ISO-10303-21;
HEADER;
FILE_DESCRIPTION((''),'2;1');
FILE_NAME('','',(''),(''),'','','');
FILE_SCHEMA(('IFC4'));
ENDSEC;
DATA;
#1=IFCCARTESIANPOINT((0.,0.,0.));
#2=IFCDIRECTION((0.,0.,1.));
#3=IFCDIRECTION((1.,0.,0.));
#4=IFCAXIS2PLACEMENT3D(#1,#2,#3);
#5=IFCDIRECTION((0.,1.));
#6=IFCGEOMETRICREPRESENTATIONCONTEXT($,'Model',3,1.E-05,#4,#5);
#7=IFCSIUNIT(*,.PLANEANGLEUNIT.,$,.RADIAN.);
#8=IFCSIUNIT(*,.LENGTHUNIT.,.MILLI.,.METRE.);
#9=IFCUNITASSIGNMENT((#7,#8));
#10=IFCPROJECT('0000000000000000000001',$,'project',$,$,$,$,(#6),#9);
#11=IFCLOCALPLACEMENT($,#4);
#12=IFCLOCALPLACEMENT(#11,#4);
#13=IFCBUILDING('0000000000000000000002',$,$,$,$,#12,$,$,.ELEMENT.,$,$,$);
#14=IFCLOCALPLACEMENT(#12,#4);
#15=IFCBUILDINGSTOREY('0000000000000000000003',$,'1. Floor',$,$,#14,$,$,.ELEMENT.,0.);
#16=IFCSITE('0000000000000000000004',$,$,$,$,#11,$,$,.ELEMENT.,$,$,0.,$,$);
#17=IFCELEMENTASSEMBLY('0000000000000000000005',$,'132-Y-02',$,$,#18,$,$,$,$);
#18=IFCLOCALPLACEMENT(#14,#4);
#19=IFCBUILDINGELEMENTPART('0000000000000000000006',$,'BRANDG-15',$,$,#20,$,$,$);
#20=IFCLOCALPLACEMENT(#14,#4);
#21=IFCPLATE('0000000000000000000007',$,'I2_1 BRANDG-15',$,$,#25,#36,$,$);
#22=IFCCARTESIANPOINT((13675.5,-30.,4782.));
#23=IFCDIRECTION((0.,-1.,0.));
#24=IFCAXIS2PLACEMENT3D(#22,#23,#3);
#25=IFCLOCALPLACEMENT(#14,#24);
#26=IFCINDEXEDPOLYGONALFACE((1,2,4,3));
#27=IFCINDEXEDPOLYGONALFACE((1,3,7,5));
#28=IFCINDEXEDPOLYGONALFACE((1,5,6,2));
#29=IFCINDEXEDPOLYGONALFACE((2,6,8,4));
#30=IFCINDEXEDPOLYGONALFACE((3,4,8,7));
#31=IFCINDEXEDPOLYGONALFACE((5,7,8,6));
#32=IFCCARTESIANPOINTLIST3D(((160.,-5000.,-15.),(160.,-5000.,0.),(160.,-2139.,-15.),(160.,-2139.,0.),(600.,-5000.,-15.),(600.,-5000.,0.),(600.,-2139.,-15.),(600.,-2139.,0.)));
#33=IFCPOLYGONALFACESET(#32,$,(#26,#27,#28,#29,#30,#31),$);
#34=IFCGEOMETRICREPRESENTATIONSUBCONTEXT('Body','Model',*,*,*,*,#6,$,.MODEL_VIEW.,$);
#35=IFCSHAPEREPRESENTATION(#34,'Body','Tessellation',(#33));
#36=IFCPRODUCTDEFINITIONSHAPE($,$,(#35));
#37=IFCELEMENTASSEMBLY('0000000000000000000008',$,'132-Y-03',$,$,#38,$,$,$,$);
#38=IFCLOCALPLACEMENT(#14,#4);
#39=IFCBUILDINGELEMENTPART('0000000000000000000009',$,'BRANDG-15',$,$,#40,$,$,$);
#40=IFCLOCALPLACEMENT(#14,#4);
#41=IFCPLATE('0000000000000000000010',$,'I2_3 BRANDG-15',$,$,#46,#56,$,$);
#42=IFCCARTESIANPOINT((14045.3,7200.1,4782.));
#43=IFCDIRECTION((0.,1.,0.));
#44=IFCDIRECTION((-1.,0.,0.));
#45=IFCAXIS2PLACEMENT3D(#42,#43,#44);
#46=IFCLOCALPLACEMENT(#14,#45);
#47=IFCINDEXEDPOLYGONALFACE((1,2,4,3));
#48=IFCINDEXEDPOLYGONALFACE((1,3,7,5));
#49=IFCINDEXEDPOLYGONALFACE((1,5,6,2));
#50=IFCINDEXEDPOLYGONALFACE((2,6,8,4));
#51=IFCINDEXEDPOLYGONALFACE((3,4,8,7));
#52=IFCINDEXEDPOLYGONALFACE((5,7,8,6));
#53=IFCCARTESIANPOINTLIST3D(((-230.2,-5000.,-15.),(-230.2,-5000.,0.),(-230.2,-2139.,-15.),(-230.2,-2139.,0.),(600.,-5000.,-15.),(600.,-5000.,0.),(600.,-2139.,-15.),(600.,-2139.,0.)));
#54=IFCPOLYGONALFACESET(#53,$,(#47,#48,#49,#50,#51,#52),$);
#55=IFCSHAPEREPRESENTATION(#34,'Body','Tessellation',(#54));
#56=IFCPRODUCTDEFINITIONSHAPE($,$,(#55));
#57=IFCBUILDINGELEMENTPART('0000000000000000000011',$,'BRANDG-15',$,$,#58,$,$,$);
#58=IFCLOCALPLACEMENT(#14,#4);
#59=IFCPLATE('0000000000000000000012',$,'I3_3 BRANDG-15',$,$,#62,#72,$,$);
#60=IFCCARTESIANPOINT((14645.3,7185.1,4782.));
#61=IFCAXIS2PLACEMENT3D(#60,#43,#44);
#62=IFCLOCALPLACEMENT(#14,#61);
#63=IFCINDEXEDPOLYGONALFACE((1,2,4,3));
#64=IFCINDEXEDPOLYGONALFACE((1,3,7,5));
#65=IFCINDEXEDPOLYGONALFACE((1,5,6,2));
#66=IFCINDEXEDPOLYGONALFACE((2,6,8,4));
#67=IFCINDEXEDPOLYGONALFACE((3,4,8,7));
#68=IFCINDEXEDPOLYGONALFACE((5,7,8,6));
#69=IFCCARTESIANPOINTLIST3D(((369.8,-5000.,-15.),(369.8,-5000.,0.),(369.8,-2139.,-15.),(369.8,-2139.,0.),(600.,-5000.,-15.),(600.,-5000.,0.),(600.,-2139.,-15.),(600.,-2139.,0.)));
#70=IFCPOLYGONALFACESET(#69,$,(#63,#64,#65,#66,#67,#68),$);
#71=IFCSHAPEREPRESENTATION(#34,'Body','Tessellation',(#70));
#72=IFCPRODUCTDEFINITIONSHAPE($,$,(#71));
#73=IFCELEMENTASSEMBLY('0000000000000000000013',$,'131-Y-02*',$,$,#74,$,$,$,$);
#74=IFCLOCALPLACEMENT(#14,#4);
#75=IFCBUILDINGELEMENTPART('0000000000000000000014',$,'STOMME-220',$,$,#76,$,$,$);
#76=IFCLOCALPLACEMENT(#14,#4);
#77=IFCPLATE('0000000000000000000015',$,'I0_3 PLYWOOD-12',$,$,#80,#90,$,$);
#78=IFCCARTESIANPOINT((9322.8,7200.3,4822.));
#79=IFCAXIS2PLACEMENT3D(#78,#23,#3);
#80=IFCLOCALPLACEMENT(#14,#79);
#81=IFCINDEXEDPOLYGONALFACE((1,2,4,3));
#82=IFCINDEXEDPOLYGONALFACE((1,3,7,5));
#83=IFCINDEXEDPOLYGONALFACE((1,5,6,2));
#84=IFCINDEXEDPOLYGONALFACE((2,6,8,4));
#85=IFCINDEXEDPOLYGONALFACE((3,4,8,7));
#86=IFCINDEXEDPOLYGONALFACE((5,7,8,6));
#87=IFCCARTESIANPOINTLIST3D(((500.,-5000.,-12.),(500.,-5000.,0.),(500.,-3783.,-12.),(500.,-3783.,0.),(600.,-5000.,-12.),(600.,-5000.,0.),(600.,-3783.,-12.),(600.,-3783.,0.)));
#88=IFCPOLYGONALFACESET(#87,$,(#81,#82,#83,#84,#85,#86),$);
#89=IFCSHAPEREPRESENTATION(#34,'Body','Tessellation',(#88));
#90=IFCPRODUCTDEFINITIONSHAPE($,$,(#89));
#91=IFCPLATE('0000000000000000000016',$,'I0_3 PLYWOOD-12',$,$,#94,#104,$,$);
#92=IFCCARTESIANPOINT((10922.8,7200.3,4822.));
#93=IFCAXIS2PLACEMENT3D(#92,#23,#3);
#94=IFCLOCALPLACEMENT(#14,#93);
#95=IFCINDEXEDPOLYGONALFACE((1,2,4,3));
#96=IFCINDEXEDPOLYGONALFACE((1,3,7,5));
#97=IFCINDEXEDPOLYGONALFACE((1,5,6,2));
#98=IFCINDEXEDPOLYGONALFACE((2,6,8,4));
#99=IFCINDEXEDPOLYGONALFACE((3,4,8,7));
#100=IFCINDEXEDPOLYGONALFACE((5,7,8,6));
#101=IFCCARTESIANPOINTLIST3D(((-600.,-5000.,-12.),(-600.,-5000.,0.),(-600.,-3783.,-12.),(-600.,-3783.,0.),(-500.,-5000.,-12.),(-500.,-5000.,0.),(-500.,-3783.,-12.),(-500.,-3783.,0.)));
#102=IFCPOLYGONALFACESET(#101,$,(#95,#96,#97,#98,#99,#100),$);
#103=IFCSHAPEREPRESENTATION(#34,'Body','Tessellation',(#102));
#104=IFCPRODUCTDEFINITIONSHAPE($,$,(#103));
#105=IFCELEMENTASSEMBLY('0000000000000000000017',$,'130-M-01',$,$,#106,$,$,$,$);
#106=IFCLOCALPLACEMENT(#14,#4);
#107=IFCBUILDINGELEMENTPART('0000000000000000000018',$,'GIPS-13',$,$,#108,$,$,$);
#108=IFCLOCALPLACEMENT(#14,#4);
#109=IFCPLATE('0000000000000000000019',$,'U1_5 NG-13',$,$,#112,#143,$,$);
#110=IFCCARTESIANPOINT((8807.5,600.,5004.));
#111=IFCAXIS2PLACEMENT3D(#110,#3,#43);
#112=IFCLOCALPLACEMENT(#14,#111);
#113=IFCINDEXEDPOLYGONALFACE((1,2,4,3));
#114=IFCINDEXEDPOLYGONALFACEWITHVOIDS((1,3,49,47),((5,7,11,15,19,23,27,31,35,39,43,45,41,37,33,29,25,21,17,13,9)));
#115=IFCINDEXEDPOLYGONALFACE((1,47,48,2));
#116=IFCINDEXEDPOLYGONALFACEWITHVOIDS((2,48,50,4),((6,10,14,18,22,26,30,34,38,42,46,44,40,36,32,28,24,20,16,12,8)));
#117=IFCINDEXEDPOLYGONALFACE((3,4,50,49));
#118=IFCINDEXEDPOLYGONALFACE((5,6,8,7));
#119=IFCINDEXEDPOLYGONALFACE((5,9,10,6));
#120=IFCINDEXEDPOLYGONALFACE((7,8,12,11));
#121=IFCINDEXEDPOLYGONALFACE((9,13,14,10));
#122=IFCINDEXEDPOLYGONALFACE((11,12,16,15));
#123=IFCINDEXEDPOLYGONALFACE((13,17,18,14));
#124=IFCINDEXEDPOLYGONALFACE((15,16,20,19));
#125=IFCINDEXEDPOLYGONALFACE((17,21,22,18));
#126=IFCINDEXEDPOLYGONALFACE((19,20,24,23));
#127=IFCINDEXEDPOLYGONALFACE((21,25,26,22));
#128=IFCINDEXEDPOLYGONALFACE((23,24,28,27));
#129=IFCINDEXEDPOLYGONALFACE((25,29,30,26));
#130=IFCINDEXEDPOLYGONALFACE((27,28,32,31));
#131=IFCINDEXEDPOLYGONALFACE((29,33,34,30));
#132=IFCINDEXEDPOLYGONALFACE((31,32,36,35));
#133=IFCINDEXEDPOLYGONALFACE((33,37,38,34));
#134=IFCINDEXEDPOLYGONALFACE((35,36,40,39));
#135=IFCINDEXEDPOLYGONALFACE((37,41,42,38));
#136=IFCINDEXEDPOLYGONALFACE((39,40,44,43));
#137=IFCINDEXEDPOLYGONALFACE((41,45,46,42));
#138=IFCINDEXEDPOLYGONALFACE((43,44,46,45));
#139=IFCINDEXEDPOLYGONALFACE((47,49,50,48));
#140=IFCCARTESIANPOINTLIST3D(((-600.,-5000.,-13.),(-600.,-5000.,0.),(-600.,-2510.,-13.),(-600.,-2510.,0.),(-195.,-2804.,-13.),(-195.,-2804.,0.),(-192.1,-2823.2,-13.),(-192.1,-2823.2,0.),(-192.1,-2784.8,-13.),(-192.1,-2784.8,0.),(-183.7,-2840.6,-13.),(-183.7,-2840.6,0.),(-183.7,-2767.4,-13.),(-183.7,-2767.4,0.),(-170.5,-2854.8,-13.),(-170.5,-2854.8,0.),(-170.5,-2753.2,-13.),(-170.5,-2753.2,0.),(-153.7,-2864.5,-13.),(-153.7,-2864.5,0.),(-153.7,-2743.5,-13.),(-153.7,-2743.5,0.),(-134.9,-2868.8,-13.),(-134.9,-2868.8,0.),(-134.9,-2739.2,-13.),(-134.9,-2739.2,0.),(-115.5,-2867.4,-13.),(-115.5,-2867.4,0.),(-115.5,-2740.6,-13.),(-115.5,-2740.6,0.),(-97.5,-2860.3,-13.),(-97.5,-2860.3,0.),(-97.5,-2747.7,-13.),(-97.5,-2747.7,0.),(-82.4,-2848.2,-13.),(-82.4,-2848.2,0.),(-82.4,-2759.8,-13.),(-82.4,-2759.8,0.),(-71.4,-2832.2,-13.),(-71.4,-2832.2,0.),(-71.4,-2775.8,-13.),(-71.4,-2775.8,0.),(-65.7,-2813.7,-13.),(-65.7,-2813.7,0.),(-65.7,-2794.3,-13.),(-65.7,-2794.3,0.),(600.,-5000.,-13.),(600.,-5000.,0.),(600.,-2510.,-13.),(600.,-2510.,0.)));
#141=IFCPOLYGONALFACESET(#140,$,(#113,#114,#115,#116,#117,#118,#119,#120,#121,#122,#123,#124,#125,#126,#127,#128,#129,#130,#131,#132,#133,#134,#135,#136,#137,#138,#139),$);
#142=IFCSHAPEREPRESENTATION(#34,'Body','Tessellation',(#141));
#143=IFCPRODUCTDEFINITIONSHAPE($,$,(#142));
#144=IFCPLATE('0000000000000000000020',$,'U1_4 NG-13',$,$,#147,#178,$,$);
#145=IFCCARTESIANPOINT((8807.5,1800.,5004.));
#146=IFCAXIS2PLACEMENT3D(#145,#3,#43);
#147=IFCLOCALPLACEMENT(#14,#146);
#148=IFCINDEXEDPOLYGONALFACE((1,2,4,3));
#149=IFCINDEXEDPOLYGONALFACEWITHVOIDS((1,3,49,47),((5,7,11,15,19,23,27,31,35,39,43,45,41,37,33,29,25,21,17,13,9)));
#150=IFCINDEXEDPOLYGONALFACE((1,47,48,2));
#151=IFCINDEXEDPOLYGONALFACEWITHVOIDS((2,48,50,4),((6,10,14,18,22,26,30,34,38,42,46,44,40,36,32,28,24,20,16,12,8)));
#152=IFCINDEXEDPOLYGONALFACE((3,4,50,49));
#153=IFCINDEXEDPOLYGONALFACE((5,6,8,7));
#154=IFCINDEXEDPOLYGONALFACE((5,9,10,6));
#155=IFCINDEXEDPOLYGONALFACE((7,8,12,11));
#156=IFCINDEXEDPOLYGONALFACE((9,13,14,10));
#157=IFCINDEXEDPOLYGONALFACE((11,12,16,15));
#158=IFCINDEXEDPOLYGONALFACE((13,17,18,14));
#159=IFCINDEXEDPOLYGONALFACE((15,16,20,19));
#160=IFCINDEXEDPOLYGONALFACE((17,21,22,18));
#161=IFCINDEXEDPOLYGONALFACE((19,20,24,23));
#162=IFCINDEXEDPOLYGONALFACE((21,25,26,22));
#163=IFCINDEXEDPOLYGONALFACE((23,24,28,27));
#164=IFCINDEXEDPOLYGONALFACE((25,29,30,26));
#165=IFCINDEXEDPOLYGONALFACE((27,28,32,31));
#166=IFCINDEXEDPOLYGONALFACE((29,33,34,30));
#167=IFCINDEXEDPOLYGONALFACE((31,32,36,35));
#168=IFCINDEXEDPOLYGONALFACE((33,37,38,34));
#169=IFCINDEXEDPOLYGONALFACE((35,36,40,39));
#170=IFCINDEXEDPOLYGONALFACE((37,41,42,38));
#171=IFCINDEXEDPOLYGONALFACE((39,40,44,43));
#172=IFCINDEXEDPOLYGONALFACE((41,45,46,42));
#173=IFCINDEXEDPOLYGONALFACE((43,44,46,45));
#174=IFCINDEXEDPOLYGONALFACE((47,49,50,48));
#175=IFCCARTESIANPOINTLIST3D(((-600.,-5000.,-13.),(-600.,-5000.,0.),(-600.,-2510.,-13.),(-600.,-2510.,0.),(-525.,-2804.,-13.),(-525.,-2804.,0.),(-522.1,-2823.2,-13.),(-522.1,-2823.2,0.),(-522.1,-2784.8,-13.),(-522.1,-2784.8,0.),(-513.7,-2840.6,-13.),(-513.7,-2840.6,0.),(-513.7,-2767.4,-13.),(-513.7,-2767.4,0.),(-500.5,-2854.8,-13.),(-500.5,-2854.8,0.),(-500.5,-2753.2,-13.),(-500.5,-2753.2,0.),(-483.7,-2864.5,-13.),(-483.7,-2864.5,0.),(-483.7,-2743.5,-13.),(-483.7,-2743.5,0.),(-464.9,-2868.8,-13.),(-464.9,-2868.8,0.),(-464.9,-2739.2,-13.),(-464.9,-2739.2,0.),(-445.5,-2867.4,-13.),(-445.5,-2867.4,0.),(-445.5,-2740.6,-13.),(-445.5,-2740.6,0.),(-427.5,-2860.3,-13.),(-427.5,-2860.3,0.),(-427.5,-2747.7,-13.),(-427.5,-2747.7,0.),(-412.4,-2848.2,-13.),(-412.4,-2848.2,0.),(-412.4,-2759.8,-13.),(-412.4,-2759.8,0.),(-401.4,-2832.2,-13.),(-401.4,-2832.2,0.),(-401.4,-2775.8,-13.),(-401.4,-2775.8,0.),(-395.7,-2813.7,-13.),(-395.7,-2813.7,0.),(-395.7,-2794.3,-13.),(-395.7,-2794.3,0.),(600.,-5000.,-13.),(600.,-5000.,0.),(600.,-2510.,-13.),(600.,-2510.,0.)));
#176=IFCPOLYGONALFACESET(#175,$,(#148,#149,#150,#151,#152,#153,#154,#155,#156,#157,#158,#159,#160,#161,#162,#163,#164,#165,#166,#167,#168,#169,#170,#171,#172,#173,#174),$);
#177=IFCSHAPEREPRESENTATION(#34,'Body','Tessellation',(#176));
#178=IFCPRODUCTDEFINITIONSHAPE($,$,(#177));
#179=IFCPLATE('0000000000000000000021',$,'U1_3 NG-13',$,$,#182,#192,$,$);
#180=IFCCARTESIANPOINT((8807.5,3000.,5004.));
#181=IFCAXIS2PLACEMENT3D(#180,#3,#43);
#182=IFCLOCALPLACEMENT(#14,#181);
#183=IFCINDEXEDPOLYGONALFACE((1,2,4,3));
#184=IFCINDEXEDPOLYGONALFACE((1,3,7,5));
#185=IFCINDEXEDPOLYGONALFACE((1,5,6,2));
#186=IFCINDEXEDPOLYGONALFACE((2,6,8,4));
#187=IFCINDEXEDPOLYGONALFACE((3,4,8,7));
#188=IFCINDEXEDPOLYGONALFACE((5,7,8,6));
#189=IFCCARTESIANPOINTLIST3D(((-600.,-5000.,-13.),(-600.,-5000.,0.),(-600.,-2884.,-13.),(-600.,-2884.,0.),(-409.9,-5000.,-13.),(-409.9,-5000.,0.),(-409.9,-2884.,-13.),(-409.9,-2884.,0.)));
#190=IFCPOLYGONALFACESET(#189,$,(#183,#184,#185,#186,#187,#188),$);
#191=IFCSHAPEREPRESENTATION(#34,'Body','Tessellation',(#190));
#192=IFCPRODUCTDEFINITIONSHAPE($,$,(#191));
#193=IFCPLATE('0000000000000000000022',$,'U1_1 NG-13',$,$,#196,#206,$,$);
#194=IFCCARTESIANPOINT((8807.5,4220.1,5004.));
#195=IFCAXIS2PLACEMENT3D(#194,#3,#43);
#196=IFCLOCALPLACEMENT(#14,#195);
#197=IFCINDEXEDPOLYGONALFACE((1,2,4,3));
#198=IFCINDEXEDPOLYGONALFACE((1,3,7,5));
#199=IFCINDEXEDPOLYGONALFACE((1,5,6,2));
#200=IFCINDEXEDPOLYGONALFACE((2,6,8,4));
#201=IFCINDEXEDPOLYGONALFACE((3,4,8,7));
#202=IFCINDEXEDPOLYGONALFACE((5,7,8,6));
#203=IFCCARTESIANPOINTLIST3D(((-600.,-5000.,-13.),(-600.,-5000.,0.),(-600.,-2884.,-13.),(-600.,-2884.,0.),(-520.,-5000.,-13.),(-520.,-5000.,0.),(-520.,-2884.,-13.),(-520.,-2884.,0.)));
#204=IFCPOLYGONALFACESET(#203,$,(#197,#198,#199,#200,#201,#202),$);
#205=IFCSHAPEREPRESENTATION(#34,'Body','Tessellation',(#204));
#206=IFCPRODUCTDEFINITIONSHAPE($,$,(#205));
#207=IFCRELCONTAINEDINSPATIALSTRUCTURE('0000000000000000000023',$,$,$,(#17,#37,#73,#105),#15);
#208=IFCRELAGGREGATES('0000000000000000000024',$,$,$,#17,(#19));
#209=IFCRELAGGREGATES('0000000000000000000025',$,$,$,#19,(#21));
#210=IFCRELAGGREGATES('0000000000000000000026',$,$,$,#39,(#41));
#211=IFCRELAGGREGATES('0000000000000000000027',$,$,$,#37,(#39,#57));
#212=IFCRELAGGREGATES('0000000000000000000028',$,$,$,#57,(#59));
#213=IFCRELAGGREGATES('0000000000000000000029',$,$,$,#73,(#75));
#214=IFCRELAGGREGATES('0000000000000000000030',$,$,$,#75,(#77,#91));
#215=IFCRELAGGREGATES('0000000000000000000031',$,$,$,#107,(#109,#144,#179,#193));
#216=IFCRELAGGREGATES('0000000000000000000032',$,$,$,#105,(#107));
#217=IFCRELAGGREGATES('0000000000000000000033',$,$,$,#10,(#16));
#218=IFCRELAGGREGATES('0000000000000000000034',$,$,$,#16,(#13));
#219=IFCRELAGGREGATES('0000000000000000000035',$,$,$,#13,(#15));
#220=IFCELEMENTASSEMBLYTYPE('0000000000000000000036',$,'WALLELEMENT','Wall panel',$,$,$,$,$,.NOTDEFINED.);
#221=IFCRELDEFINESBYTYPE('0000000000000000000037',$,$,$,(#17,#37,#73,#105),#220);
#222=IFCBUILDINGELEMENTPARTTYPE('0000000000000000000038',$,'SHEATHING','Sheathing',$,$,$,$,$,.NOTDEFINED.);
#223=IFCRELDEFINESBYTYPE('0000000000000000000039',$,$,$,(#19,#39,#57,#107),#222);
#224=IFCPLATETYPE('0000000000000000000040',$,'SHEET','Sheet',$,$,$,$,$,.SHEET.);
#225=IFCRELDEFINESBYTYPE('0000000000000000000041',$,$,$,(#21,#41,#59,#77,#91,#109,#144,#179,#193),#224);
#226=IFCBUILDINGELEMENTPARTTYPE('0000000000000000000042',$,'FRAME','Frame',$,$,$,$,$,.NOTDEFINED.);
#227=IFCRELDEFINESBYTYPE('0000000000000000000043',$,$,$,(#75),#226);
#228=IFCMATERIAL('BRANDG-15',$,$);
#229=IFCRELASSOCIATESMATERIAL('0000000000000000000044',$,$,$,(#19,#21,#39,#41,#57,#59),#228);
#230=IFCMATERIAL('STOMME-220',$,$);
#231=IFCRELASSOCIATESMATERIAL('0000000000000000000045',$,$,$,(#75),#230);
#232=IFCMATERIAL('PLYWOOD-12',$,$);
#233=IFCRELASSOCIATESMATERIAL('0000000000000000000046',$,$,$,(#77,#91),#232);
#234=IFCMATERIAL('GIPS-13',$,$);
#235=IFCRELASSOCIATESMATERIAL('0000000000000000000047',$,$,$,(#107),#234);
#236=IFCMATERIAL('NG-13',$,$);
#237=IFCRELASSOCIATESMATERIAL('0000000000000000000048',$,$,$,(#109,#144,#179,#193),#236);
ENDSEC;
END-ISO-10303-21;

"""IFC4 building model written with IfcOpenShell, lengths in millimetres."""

from ifc_helpers import new_model, si_unit, direction, frame, origin_with_axes, origin_2d_with_axis, place, context, subcontext, project, spatial, rectangle, circle, extrude, boolean, material, type_object, element, aggregate, save


model = new_model("IFC4")

# Units and contexts
model_context = context("Model", 3, precision=1e-05, world=origin_with_axes(), true_north=direction((0.0, 1.0)))
body_context = subcontext(model_context, "Body", "Model", "MODEL_VIEW")
ifc_project = project(units=[si_unit("PLANEANGLEUNIT", "RADIAN"), si_unit("LENGTHUNIT", "METRE", prefix="MILLI")], contexts=[model_context])

# Site, building, storey
site_placement = place(None, origin_with_axes())
site = spatial("IfcSite", under=ifc_project, at=site_placement, CompositionType="ELEMENT", RefElevation=0.0)
building_placement = place(site_placement, origin_with_axes())
building = spatial("IfcBuilding", under=site, at=building_placement, CompositionType="ELEMENT")
storey_placement = place(building_placement, origin_with_axes())
storey = spatial("IfcBuildingStorey", under=building, at=storey_placement, Name="1. Floor", CompositionType="ELEMENT", Elevation=0.0)

# Element assembly, building element part, plate
element_assembly_type = type_object("IfcElementAssemblyType", Name="WALLELEMENT", Description="Wall panel", PredefinedType="NOTDEFINED")
assembly_1_placement = place(storey_placement, origin_with_axes())
assembly_1 = element("IfcElementAssembly", 1, at=assembly_1_placement, inside=storey, type_object=element_assembly_type, Name="132-Y-02")
ifc_material_1 = material(Name="BRANDG-15")
building_element_part_type_1 = type_object("IfcBuildingElementPartType", Name="SHEATHING", Description="Sheathing", PredefinedType="NOTDEFINED")
building_element_part_1_placement = place(storey_placement, origin_with_axes())
building_element_part_1 = element("IfcBuildingElementPart", 2, at=building_element_part_1_placement, type_object=building_element_part_type_1, material=ifc_material_1, Name="BRANDG-15")
aggregate(assembly_1, [building_element_part_1])
plate_type = type_object("IfcPlateType", Name="SHEET", Description="Sheet", PredefinedType="SHEET")
plate_1_placement = place(storey_placement, frame((13675.5, -30.0, 4782.0), z_axis=(0.0, -1.0, 0.0), x_axis=(1.0, 0.0, 0.0)))
plate_1 = element("IfcPlate", 3, at=plate_1_placement, type_object=plate_type, material=ifc_material_1, Name="I2_1 BRANDG-15", context=body_context, shape_type="SweptSolid", body=[
    extrude(rectangle(XDim=15.0, YDim=440.0, at=origin_2d_with_axis()), frame((380.0, -5000.0, -7.5), z_axis=(0.0, 1.0, 0.0), x_axis=(0.0, 0.0, 1.0)), (0.0, 0.0, 1.0), 2861.0),
])
aggregate(building_element_part_1, [plate_1])

# Element assembly, building element parts, plates
assembly_2_placement = place(storey_placement, origin_with_axes())
assembly_2 = element("IfcElementAssembly", 4, at=assembly_2_placement, inside=storey, type_object=element_assembly_type, Name="132-Y-03")
building_element_part_2_placement = place(storey_placement, origin_with_axes())
building_element_part_2 = element("IfcBuildingElementPart", 5, at=building_element_part_2_placement, type_object=building_element_part_type_1, material=ifc_material_1, Name="BRANDG-15")
plate_2_placement = place(storey_placement, frame((14045.3, 7200.1, 4782.0), z_axis=(0.0, 1.0, 0.0), x_axis=(-1.0, 0.0, 0.0)))
plate_2 = element("IfcPlate", 6, at=plate_2_placement, type_object=plate_type, material=ifc_material_1, Name="I2_3 BRANDG-15", context=body_context, shape_type="SweptSolid", body=[
    extrude(rectangle(XDim=15.0, YDim=830.2, at=origin_2d_with_axis()), frame((184.9, -5000.0, -7.5), z_axis=(0.0, 1.0, 0.0), x_axis=(0.0, 0.0, 1.0)), (0.0, 0.0, 1.0), 2861.0),
])
aggregate(building_element_part_2, [plate_2])
building_element_part_3_placement = place(storey_placement, origin_with_axes())
building_element_part_3 = element("IfcBuildingElementPart", 7, at=building_element_part_3_placement, type_object=building_element_part_type_1, material=ifc_material_1, Name="BRANDG-15")
aggregate(assembly_2, [building_element_part_2, building_element_part_3])
plate_3_placement = place(storey_placement, frame((14645.3, 7185.1, 4782.0), z_axis=(0.0, 1.0, 0.0), x_axis=(-1.0, 0.0, 0.0)))
plate_3 = element("IfcPlate", 8, at=plate_3_placement, type_object=plate_type, material=ifc_material_1, Name="I3_3 BRANDG-15", context=body_context, shape_type="SweptSolid", body=[
    extrude(rectangle(XDim=15.0, YDim=230.2, at=origin_2d_with_axis()), frame((484.9, -5000.0, -7.5), z_axis=(0.0, 1.0, 0.0), x_axis=(0.0, 0.0, 1.0)), (0.0, 0.0, 1.0), 2861.0),
])
aggregate(building_element_part_3, [plate_3])

# Element assembly, building element part, plates
assembly_3_placement = place(storey_placement, origin_with_axes())
assembly_3 = element("IfcElementAssembly", 9, at=assembly_3_placement, inside=storey, type_object=element_assembly_type, Name="131-Y-02*")
ifc_material_2 = material(Name="STOMME-220")
building_element_part_type_2 = type_object("IfcBuildingElementPartType", Name="FRAME", Description="Frame", PredefinedType="NOTDEFINED")
building_element_part_4_placement = place(storey_placement, origin_with_axes())
building_element_part_4 = element("IfcBuildingElementPart", 10, at=building_element_part_4_placement, type_object=building_element_part_type_2, material=ifc_material_2, Name="STOMME-220")
aggregate(assembly_3, [building_element_part_4])
ifc_material_3 = material(Name="PLYWOOD-12")
plate_4_placement = place(storey_placement, frame((9322.8, 7200.3, 4822.0), z_axis=(0.0, -1.0, 0.0), x_axis=(1.0, 0.0, 0.0)))
plate_4 = element("IfcPlate", 11, at=plate_4_placement, type_object=plate_type, material=ifc_material_3, Name="I0_3 PLYWOOD-12", context=body_context, shape_type="SweptSolid", body=[
    extrude(rectangle(XDim=12.0, YDim=100.0, at=origin_2d_with_axis()), frame((550.0, -5000.0, -6.0), z_axis=(0.0, 1.0, 0.0), x_axis=(0.0, 0.0, 1.0)), (0.0, 0.0, 1.0), 1217.0),
])
plate_5_placement = place(storey_placement, frame((10922.8, 7200.3, 4822.0), z_axis=(0.0, -1.0, 0.0), x_axis=(1.0, 0.0, 0.0)))
plate_5 = element("IfcPlate", 12, at=plate_5_placement, type_object=plate_type, material=ifc_material_3, Name="I0_3 PLYWOOD-12", context=body_context, shape_type="SweptSolid", body=[
    extrude(rectangle(XDim=12.0, YDim=100.0, at=origin_2d_with_axis()), frame((-550.0, -5000.0, -6.0), z_axis=(0.0, 1.0, 0.0), x_axis=(0.0, 0.0, 1.0)), (0.0, 0.0, 1.0), 1217.0),
])
aggregate(building_element_part_4, [plate_4, plate_5])

# Element assembly, building element part, plates
assembly_4_placement = place(storey_placement, origin_with_axes())
assembly_4 = element("IfcElementAssembly", 13, at=assembly_4_placement, inside=storey, type_object=element_assembly_type, Name="130-M-01")
ifc_material_4 = material(Name="GIPS-13")
building_element_part_5_placement = place(storey_placement, origin_with_axes())
building_element_part_5 = element("IfcBuildingElementPart", 14, at=building_element_part_5_placement, type_object=building_element_part_type_1, material=ifc_material_4, Name="GIPS-13")
ifc_material_5 = material(Name="NG-13")
plate_6_placement = place(storey_placement, frame((8807.5, 600.0, 5004.0), z_axis=(1.0, 0.0, 0.0), x_axis=(0.0, 1.0, 0.0)))
plate_6 = element("IfcPlate", 15, at=plate_6_placement, type_object=plate_type, material=ifc_material_5, Name="U1_5 NG-13", context=body_context, shape_type="CSG", body=[
    boolean("DIFFERENCE", extrude(rectangle(XDim=13.0, YDim=1200.0, at=origin_2d_with_axis()), frame((0.0, -5000.0, -6.5), z_axis=(0.0, 1.0, 0.0), x_axis=(0.0, 0.0, 1.0)), (0.0, 0.0, 1.0), 2490.0), extrude(circle(Radius=65.0, at=origin_2d_with_axis()), frame((-130.0, -2804.0, 14.0), z_axis=(0.0, 0.0, 1.0), x_axis=(-1.0, 0.0, 0.0)), (0.0, 0.0, -1.0), 65.0)),
])
plate_7_placement = place(storey_placement, frame((8807.5, 1800.0, 5004.0), z_axis=(1.0, 0.0, 0.0), x_axis=(0.0, 1.0, 0.0)))
plate_7 = element("IfcPlate", 16, at=plate_7_placement, type_object=plate_type, material=ifc_material_5, Name="U1_4 NG-13", context=body_context, shape_type="CSG", body=[
    boolean("DIFFERENCE", extrude(rectangle(XDim=13.0, YDim=1200.0, at=origin_2d_with_axis()), frame((0.0, -5000.0, -6.5), z_axis=(0.0, 1.0, 0.0), x_axis=(0.0, 0.0, 1.0)), (0.0, 0.0, 1.0), 2490.0), extrude(circle(Radius=65.0, at=origin_2d_with_axis()), frame((-460.0, -2804.0, 14.0), z_axis=(0.0, 0.0, 1.0), x_axis=(-1.0, 0.0, 0.0)), (0.0, 0.0, -1.0), 65.0)),
])
plate_8_placement = place(storey_placement, frame((8807.5, 3000.0, 5004.0), z_axis=(1.0, 0.0, 0.0), x_axis=(0.0, 1.0, 0.0)))
plate_8 = element("IfcPlate", 17, at=plate_8_placement, type_object=plate_type, material=ifc_material_5, Name="U1_3 NG-13", context=body_context, shape_type="SweptSolid", body=[
    extrude(rectangle(XDim=13.0, YDim=190.1, at=origin_2d_with_axis()), frame((-504.9, -5000.0, -6.5), z_axis=(0.0, 1.0, 0.0), x_axis=(0.0, 0.0, 1.0)), (0.0, 0.0, 1.0), 2116.0),
])
plate_9_placement = place(storey_placement, frame((8807.5, 4220.1, 5004.0), z_axis=(1.0, 0.0, 0.0), x_axis=(0.0, 1.0, 0.0)))
plate_9 = element("IfcPlate", 18, at=plate_9_placement, type_object=plate_type, material=ifc_material_5, Name="U1_1 NG-13", context=body_context, shape_type="SweptSolid", body=[
    extrude(rectangle(XDim=13.0, YDim=80.0, at=origin_2d_with_axis()), frame((-560.0, -5000.0, -6.5), z_axis=(0.0, 1.0, 0.0), x_axis=(0.0, 0.0, 1.0)), (0.0, 0.0, 1.0), 2116.0),
])
aggregate(building_element_part_5, [plate_6, plate_7, plate_8, plate_9])
aggregate(assembly_4, [building_element_part_5])

save(model, "model.ifc")
